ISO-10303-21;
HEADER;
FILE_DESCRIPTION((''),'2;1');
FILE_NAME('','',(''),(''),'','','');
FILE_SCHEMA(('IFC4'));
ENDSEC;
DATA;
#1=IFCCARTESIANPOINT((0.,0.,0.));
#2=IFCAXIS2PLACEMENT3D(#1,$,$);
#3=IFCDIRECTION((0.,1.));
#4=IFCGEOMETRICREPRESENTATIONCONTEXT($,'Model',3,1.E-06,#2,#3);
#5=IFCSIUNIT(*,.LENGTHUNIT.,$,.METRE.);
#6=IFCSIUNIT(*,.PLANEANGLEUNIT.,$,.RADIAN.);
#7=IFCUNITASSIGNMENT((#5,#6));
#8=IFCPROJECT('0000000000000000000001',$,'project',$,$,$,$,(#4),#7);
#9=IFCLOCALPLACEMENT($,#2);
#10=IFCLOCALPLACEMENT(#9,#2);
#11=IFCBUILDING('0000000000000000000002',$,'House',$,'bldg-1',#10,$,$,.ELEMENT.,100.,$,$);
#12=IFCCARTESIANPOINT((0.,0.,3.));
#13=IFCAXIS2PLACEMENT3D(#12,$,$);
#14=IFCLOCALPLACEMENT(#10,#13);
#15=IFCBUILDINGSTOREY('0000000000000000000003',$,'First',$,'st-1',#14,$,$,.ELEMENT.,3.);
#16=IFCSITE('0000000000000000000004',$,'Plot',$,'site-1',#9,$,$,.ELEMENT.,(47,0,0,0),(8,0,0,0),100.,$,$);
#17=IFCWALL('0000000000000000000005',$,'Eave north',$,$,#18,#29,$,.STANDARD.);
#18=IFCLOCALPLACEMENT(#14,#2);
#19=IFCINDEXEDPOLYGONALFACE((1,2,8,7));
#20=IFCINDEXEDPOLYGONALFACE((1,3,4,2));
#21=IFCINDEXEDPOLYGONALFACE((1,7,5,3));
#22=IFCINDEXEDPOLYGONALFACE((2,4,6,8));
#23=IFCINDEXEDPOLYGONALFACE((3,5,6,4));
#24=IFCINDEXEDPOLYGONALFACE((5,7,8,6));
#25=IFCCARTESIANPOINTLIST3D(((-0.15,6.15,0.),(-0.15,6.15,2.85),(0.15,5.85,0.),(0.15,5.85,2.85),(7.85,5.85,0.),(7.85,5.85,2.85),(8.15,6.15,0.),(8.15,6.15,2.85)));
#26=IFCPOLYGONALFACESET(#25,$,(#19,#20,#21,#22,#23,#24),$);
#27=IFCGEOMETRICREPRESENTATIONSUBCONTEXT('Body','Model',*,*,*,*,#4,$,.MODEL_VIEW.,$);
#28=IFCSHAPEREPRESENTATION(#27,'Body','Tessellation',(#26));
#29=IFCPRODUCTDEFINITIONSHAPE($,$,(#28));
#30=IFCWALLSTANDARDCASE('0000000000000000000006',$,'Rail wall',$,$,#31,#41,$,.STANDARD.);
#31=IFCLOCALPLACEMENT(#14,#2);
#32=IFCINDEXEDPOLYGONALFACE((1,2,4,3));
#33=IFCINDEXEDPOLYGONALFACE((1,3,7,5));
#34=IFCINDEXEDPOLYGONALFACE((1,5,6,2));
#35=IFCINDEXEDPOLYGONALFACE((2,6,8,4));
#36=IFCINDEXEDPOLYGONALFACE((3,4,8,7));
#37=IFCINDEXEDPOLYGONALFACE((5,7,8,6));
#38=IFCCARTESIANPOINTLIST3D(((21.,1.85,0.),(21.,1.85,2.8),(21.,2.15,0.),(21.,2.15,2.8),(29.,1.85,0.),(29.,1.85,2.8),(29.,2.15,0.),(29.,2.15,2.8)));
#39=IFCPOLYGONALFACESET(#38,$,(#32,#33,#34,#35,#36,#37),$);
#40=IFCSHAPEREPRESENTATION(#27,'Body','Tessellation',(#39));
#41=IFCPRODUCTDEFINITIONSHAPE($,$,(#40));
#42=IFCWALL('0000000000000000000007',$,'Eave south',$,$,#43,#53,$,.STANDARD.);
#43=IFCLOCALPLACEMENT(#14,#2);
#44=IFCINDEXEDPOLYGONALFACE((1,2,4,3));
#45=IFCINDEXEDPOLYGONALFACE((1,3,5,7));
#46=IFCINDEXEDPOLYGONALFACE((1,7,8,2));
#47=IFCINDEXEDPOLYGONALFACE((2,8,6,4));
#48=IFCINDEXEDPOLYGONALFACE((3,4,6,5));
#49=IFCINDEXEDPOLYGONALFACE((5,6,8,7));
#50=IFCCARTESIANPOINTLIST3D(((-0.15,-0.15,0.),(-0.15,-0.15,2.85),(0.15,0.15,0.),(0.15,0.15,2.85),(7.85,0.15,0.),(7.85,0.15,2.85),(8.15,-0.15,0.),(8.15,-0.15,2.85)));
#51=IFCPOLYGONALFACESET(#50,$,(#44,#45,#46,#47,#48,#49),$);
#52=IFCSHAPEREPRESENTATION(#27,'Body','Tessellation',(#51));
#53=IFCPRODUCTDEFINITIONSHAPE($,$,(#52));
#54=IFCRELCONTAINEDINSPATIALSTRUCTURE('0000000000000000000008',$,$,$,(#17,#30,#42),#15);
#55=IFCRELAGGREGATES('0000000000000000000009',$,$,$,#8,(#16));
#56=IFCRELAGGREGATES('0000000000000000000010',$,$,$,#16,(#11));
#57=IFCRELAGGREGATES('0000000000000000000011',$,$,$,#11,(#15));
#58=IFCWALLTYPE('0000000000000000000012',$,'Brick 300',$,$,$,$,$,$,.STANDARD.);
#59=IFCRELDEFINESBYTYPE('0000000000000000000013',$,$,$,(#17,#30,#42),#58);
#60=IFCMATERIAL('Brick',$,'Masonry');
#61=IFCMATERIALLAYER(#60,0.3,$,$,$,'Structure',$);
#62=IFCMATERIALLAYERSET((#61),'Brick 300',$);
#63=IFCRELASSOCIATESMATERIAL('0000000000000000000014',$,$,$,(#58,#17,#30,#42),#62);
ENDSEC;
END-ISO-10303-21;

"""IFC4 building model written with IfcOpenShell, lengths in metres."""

from ifc_helpers import new_model, si_unit, direction, frame, frame_2d, origin, place, context, subcontext, project, spatial, polyline, rectangle, outline, extrude, material, layer, layer_set, layer_usage, type_object, element, save


model = new_model("IFC4")

# Units and contexts
model_context = context("Model", 3, precision=1e-06, world=origin(), true_north=direction((0.0, 1.0)))
body_context = subcontext(model_context, "Body", "Model", "MODEL_VIEW")
ifc_project = project(units=[si_unit("LENGTHUNIT", "METRE"), si_unit("PLANEANGLEUNIT", "RADIAN")], contexts=[model_context])

# Site, building, storey
site_placement = place(None, origin())
site = spatial("IfcSite", under=ifc_project, at=site_placement, Name="Plot", ObjectType="site-1", CompositionType="ELEMENT", RefLatitude=(47, 0, 0, 0), RefLongitude=(8, 0, 0, 0), RefElevation=100.0)
building_placement = place(site_placement, origin())
building = spatial("IfcBuilding", under=site, at=building_placement, Name="House", ObjectType="bldg-1", CompositionType="ELEMENT", ElevationOfRefHeight=100.0)
storey_placement = place(building_placement, frame((0.0, 0.0, 3.0)))
storey = spatial("IfcBuildingStorey", under=building, at=storey_placement, Name="First", ObjectType="st-1", CompositionType="ELEMENT", Elevation=3.0)

# Walls
ifc_material_1 = material(Name="Brick", Category="Masonry")
ifc_layer = layer(ifc_material_1, 0.3, Category="Structure")
ifc_layer_set = layer_set([ifc_layer], Name="Brick 300")
ifc_layer_usage_1 = layer_usage(ifc_layer_set, "AXIS2", "NEGATIVE", 0.15)
wall_type = type_object("IfcWallType", Name="Brick 300", PredefinedType="STANDARD", material=ifc_layer_set)
wall_1_placement = place(storey_placement, origin())
element("IfcWall", 1, at=wall_1_placement, inside=storey, type_object=wall_type, material=ifc_layer_usage_1, Name="Eave north", PredefinedType="STANDARD", context=body_context, shape_type="SweptSolid", body=[
    extrude(outline(polyline([(8.15, 6.15), (-0.15, 6.15), (0.15, 5.85), (7.85, 5.85), (8.15, 6.15)])), origin(), (0.0, 0.0, 1.0), 2.85),
])
ifc_layer_usage_2 = layer_usage(ifc_layer_set, "AXIS2", "NEGATIVE", 0.15)
wall_2_placement = place(storey_placement, frame((21.0, 2.0, 0.0), z_axis=(0.0, 0.0, 1.0), x_axis=(1.0, 0.0, 0.0)))
element("IfcWallStandardCase", 2, at=wall_2_placement, inside=storey, type_object=wall_type, material=ifc_layer_usage_2, Name="Rail wall", PredefinedType="STANDARD", context=body_context, shape_type="SweptSolid", body=[
    extrude(rectangle(XDim=8.0, YDim=0.3, at=frame_2d((4.0, 0.0))), origin(), (0.0, 0.0, 1.0), 2.8),
])
ifc_layer_usage_3 = layer_usage(ifc_layer_set, "AXIS2", "NEGATIVE", 0.15)
wall_3_placement = place(storey_placement, origin())
element("IfcWall", 3, at=wall_3_placement, inside=storey, type_object=wall_type, material=ifc_layer_usage_3, Name="Eave south", PredefinedType="STANDARD", context=body_context, shape_type="SweptSolid", body=[
    extrude(outline(polyline([(-0.15, -0.15), (8.15, -0.15), (7.85, 0.15), (0.15, 0.15), (-0.15, -0.15)])), origin(), (0.0, 0.0, 1.0), 2.85),
])

save(model, "model.ifc")
